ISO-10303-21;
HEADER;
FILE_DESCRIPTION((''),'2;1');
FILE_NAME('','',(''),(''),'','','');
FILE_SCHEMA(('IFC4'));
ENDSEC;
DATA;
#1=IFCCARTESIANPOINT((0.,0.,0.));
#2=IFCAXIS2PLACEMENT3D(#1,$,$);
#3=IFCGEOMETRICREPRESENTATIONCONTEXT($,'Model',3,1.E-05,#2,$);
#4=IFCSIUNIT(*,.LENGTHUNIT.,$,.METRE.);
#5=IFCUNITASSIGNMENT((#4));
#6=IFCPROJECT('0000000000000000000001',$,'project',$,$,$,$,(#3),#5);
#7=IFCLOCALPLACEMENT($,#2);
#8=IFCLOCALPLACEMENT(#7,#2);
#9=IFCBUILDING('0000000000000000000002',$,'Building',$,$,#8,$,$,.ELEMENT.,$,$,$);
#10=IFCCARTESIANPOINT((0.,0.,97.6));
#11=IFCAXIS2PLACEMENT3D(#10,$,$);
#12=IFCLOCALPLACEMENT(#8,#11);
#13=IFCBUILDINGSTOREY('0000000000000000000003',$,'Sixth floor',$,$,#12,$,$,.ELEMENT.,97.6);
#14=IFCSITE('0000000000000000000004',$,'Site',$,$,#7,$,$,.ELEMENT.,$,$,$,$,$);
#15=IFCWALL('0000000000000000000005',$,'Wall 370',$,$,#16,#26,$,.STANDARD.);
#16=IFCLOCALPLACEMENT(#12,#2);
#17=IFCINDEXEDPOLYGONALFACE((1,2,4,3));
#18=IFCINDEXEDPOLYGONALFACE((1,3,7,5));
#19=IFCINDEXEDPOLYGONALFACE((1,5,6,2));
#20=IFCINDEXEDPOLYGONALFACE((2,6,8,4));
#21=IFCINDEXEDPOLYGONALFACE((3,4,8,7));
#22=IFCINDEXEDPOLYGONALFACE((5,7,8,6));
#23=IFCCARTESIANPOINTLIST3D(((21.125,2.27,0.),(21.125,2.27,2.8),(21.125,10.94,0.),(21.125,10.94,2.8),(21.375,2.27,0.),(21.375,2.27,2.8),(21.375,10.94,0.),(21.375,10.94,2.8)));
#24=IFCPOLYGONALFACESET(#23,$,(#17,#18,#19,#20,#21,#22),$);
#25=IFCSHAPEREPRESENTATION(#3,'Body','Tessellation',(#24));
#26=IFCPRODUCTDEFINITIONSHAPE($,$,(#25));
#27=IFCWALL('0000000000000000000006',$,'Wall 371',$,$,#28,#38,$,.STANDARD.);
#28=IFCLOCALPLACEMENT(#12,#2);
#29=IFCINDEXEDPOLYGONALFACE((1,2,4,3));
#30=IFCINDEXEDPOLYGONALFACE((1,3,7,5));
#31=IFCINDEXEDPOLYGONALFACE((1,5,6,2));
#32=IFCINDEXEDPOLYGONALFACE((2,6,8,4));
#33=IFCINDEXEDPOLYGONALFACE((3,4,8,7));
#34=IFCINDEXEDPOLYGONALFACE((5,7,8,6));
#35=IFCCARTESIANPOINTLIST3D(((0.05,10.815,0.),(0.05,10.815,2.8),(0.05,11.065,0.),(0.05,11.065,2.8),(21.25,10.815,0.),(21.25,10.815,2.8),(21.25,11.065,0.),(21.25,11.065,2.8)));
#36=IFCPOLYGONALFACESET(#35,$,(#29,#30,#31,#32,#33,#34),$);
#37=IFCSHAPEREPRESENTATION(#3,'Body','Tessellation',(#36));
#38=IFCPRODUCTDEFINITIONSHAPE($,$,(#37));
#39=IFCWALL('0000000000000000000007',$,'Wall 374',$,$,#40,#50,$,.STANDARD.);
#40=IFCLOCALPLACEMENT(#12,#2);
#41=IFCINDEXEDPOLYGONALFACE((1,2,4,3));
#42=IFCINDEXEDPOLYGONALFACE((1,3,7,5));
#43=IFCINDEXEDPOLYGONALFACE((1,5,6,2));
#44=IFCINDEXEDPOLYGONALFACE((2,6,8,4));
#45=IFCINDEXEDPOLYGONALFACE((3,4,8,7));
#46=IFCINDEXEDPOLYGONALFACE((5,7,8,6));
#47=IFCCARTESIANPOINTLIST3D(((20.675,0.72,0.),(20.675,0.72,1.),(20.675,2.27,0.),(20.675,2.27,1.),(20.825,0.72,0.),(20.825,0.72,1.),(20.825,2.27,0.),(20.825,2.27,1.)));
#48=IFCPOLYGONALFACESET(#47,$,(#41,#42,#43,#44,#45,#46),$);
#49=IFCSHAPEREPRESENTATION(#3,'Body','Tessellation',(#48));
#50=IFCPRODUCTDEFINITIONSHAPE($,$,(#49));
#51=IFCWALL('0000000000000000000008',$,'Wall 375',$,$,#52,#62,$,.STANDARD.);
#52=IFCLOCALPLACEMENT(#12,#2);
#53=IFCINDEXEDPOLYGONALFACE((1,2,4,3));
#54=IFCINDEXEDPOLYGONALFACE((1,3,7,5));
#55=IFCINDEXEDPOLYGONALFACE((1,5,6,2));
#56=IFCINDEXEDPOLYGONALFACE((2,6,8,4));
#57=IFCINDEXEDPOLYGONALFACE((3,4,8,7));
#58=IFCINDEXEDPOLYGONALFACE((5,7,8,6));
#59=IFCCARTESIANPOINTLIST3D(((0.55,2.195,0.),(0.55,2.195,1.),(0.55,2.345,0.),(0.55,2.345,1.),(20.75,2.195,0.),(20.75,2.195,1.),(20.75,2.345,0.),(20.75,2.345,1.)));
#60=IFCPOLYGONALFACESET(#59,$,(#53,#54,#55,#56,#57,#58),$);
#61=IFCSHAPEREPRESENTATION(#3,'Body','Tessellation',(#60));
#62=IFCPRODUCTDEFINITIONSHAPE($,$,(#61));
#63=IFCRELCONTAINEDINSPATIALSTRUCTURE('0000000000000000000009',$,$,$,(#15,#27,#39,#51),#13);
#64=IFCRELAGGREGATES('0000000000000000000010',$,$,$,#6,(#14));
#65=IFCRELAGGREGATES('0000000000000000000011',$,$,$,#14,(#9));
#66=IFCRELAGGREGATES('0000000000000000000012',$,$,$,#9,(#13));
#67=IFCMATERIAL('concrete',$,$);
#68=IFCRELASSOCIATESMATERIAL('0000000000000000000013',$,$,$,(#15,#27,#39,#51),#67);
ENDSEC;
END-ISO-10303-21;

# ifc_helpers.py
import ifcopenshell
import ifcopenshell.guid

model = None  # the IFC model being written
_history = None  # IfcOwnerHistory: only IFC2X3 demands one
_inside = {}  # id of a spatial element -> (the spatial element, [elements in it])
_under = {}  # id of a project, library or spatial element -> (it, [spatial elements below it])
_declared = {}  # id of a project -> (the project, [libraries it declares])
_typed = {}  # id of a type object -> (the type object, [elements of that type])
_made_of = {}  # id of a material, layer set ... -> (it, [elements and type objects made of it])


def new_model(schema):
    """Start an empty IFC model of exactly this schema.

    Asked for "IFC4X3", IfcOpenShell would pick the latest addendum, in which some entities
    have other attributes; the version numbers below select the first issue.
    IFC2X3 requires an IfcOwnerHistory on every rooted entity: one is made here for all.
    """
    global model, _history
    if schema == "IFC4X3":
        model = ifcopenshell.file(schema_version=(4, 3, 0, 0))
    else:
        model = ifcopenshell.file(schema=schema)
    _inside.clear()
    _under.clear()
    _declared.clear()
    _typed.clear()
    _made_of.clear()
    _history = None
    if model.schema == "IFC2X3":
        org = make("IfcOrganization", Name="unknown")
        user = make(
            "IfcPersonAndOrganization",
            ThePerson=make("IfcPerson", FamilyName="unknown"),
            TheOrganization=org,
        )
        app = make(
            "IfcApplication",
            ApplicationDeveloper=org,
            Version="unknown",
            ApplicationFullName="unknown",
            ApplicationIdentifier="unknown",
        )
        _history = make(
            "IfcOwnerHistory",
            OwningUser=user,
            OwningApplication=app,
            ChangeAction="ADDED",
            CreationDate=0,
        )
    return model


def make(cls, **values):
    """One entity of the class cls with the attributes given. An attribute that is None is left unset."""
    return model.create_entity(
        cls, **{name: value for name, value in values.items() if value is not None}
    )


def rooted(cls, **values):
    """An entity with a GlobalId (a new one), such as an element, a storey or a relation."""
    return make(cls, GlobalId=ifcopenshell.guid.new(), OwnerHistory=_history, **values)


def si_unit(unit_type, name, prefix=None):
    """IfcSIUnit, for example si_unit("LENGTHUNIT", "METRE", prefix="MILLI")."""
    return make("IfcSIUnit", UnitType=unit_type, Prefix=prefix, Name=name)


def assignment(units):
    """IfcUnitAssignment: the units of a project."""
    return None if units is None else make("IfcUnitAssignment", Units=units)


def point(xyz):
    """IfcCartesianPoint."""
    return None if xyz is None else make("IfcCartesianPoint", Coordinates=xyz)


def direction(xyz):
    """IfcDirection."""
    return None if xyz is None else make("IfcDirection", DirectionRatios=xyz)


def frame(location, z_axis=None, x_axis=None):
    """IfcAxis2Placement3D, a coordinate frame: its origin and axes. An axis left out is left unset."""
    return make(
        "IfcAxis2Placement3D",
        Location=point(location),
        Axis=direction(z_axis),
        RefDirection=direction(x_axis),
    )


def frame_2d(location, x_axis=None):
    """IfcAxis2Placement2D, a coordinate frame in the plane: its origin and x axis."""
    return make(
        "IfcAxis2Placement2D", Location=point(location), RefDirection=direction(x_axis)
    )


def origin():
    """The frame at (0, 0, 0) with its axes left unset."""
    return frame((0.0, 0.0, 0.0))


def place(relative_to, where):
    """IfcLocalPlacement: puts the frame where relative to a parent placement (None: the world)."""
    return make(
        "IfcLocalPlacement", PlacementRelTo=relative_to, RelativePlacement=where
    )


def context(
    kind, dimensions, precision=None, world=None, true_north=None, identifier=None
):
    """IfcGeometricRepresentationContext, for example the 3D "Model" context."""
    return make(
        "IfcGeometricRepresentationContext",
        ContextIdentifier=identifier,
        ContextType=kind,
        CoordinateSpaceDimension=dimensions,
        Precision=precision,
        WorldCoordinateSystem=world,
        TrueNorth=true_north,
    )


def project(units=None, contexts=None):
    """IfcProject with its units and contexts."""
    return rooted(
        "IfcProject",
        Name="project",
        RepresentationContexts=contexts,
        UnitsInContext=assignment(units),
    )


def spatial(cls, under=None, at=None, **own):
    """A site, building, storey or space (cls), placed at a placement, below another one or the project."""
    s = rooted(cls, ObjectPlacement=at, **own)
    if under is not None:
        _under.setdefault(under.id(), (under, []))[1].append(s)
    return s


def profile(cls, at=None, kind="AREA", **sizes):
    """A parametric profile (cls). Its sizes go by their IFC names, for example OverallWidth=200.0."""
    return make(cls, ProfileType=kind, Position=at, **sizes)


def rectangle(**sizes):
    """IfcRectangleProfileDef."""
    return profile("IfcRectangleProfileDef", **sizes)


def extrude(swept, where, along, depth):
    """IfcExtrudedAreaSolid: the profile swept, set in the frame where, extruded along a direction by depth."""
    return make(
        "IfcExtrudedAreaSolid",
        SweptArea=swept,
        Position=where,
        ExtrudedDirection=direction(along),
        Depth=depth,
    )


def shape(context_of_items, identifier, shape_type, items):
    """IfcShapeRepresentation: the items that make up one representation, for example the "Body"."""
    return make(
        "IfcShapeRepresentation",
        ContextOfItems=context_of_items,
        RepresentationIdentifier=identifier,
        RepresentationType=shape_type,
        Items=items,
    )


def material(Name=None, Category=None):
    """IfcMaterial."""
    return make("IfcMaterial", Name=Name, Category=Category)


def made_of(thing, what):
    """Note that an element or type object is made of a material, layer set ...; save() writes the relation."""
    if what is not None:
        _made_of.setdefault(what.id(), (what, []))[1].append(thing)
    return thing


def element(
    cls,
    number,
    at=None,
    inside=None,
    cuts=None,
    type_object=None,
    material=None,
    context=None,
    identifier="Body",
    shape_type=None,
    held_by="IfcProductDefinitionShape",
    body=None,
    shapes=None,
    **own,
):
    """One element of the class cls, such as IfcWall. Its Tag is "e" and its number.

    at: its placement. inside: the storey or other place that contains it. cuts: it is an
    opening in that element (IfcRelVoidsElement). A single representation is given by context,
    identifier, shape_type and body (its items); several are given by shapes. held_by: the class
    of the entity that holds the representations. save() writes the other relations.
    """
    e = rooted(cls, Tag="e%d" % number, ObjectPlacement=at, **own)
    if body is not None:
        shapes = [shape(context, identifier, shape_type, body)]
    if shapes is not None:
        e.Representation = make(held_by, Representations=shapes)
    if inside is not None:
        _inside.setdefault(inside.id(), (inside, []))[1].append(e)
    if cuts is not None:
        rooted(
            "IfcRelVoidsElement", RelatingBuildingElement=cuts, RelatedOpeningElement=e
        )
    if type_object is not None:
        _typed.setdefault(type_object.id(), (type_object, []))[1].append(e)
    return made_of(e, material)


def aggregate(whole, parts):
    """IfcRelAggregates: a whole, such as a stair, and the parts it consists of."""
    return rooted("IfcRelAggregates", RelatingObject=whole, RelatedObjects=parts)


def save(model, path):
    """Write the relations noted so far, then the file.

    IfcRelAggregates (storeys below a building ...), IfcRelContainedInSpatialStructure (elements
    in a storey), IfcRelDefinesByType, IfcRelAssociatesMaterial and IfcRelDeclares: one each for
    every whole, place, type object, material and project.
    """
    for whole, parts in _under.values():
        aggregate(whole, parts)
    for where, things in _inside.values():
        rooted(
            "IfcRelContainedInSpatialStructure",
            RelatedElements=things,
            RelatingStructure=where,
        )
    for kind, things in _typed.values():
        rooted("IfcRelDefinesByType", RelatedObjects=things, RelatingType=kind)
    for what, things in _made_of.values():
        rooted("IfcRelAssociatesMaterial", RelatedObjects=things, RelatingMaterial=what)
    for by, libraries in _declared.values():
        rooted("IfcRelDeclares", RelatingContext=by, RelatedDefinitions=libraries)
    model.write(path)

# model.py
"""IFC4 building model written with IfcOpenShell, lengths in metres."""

from ifc_helpers import new_model, si_unit, frame, frame_2d, origin, place, context, project, spatial, rectangle, extrude, material, element, save


model = new_model("IFC4")

# Units and contexts
model_context = context("Model", 3, precision=1e-05, world=origin())
ifc_project = project(units=[si_unit("LENGTHUNIT", "METRE")], contexts=[model_context])

# Site, building, storey
site_placement = place(None, origin())
site = spatial("IfcSite", under=ifc_project, at=site_placement, Name="Site", CompositionType="ELEMENT")
building_placement = place(site_placement, origin())
building = spatial("IfcBuilding", under=site, at=building_placement, Name="Building", CompositionType="ELEMENT")
storey_placement = place(building_placement, frame((0.0, 0.0, 97.6)))
storey = spatial("IfcBuildingStorey", under=building, at=storey_placement, Name="Sixth floor", CompositionType="ELEMENT", Elevation=97.6)

# Walls
ifc_material = material(Name="concrete")
wall_1_placement = place(storey_placement, frame((21.25, 2.27, 0.0), z_axis=(0.0, 0.0, 1.0), x_axis=(0.0, 1.0, 0.0)))
element("IfcWall", 1, at=wall_1_placement, inside=storey, material=ifc_material, Name="Wall 370", PredefinedType="STANDARD", context=model_context, shape_type="SweptSolid", body=[
    extrude(rectangle(XDim=8.67, YDim=0.25, at=frame_2d((4.335, 0.0))), origin(), (0.0, 0.0, 1.0), 2.8),
])
wall_2_placement = place(storey_placement, frame((21.25, 10.94, 0.0), z_axis=(0.0, 0.0, 1.0), x_axis=(-1.0, 0.0, 0.0)))
element("IfcWall", 2, at=wall_2_placement, inside=storey, material=ifc_material, Name="Wall 371", PredefinedType="STANDARD", context=model_context, shape_type="SweptSolid", body=[
    extrude(rectangle(XDim=21.2, YDim=0.25, at=frame_2d((10.6, 0.0))), origin(), (0.0, 0.0, 1.0), 2.8),
])
wall_3_placement = place(storey_placement, frame((20.75, 0.72, 0.0), z_axis=(0.0, 0.0, 1.0), x_axis=(0.0, 1.0, 0.0)))
element("IfcWall", 3, at=wall_3_placement, inside=storey, material=ifc_material, Name="Wall 374", PredefinedType="STANDARD", context=model_context, shape_type="SweptSolid", body=[
    extrude(rectangle(XDim=1.55, YDim=0.15, at=frame_2d((0.775, 0.0))), origin(), (0.0, 0.0, 1.0), 1.0),
])
wall_4_placement = place(storey_placement, frame((20.75, 2.27, 0.0), z_axis=(0.0, 0.0, 1.0), x_axis=(-1.0, 0.0, 0.0)))
element("IfcWall", 4, at=wall_4_placement, inside=storey, material=ifc_material, Name="Wall 375", PredefinedType="STANDARD", context=model_context, shape_type="SweptSolid", body=[
    extrude(rectangle(XDim=20.2, YDim=0.15, at=frame_2d((10.1, 0.0))), origin(), (0.0, 0.0, 1.0), 1.0),
])

save(model, "model.ifc")
